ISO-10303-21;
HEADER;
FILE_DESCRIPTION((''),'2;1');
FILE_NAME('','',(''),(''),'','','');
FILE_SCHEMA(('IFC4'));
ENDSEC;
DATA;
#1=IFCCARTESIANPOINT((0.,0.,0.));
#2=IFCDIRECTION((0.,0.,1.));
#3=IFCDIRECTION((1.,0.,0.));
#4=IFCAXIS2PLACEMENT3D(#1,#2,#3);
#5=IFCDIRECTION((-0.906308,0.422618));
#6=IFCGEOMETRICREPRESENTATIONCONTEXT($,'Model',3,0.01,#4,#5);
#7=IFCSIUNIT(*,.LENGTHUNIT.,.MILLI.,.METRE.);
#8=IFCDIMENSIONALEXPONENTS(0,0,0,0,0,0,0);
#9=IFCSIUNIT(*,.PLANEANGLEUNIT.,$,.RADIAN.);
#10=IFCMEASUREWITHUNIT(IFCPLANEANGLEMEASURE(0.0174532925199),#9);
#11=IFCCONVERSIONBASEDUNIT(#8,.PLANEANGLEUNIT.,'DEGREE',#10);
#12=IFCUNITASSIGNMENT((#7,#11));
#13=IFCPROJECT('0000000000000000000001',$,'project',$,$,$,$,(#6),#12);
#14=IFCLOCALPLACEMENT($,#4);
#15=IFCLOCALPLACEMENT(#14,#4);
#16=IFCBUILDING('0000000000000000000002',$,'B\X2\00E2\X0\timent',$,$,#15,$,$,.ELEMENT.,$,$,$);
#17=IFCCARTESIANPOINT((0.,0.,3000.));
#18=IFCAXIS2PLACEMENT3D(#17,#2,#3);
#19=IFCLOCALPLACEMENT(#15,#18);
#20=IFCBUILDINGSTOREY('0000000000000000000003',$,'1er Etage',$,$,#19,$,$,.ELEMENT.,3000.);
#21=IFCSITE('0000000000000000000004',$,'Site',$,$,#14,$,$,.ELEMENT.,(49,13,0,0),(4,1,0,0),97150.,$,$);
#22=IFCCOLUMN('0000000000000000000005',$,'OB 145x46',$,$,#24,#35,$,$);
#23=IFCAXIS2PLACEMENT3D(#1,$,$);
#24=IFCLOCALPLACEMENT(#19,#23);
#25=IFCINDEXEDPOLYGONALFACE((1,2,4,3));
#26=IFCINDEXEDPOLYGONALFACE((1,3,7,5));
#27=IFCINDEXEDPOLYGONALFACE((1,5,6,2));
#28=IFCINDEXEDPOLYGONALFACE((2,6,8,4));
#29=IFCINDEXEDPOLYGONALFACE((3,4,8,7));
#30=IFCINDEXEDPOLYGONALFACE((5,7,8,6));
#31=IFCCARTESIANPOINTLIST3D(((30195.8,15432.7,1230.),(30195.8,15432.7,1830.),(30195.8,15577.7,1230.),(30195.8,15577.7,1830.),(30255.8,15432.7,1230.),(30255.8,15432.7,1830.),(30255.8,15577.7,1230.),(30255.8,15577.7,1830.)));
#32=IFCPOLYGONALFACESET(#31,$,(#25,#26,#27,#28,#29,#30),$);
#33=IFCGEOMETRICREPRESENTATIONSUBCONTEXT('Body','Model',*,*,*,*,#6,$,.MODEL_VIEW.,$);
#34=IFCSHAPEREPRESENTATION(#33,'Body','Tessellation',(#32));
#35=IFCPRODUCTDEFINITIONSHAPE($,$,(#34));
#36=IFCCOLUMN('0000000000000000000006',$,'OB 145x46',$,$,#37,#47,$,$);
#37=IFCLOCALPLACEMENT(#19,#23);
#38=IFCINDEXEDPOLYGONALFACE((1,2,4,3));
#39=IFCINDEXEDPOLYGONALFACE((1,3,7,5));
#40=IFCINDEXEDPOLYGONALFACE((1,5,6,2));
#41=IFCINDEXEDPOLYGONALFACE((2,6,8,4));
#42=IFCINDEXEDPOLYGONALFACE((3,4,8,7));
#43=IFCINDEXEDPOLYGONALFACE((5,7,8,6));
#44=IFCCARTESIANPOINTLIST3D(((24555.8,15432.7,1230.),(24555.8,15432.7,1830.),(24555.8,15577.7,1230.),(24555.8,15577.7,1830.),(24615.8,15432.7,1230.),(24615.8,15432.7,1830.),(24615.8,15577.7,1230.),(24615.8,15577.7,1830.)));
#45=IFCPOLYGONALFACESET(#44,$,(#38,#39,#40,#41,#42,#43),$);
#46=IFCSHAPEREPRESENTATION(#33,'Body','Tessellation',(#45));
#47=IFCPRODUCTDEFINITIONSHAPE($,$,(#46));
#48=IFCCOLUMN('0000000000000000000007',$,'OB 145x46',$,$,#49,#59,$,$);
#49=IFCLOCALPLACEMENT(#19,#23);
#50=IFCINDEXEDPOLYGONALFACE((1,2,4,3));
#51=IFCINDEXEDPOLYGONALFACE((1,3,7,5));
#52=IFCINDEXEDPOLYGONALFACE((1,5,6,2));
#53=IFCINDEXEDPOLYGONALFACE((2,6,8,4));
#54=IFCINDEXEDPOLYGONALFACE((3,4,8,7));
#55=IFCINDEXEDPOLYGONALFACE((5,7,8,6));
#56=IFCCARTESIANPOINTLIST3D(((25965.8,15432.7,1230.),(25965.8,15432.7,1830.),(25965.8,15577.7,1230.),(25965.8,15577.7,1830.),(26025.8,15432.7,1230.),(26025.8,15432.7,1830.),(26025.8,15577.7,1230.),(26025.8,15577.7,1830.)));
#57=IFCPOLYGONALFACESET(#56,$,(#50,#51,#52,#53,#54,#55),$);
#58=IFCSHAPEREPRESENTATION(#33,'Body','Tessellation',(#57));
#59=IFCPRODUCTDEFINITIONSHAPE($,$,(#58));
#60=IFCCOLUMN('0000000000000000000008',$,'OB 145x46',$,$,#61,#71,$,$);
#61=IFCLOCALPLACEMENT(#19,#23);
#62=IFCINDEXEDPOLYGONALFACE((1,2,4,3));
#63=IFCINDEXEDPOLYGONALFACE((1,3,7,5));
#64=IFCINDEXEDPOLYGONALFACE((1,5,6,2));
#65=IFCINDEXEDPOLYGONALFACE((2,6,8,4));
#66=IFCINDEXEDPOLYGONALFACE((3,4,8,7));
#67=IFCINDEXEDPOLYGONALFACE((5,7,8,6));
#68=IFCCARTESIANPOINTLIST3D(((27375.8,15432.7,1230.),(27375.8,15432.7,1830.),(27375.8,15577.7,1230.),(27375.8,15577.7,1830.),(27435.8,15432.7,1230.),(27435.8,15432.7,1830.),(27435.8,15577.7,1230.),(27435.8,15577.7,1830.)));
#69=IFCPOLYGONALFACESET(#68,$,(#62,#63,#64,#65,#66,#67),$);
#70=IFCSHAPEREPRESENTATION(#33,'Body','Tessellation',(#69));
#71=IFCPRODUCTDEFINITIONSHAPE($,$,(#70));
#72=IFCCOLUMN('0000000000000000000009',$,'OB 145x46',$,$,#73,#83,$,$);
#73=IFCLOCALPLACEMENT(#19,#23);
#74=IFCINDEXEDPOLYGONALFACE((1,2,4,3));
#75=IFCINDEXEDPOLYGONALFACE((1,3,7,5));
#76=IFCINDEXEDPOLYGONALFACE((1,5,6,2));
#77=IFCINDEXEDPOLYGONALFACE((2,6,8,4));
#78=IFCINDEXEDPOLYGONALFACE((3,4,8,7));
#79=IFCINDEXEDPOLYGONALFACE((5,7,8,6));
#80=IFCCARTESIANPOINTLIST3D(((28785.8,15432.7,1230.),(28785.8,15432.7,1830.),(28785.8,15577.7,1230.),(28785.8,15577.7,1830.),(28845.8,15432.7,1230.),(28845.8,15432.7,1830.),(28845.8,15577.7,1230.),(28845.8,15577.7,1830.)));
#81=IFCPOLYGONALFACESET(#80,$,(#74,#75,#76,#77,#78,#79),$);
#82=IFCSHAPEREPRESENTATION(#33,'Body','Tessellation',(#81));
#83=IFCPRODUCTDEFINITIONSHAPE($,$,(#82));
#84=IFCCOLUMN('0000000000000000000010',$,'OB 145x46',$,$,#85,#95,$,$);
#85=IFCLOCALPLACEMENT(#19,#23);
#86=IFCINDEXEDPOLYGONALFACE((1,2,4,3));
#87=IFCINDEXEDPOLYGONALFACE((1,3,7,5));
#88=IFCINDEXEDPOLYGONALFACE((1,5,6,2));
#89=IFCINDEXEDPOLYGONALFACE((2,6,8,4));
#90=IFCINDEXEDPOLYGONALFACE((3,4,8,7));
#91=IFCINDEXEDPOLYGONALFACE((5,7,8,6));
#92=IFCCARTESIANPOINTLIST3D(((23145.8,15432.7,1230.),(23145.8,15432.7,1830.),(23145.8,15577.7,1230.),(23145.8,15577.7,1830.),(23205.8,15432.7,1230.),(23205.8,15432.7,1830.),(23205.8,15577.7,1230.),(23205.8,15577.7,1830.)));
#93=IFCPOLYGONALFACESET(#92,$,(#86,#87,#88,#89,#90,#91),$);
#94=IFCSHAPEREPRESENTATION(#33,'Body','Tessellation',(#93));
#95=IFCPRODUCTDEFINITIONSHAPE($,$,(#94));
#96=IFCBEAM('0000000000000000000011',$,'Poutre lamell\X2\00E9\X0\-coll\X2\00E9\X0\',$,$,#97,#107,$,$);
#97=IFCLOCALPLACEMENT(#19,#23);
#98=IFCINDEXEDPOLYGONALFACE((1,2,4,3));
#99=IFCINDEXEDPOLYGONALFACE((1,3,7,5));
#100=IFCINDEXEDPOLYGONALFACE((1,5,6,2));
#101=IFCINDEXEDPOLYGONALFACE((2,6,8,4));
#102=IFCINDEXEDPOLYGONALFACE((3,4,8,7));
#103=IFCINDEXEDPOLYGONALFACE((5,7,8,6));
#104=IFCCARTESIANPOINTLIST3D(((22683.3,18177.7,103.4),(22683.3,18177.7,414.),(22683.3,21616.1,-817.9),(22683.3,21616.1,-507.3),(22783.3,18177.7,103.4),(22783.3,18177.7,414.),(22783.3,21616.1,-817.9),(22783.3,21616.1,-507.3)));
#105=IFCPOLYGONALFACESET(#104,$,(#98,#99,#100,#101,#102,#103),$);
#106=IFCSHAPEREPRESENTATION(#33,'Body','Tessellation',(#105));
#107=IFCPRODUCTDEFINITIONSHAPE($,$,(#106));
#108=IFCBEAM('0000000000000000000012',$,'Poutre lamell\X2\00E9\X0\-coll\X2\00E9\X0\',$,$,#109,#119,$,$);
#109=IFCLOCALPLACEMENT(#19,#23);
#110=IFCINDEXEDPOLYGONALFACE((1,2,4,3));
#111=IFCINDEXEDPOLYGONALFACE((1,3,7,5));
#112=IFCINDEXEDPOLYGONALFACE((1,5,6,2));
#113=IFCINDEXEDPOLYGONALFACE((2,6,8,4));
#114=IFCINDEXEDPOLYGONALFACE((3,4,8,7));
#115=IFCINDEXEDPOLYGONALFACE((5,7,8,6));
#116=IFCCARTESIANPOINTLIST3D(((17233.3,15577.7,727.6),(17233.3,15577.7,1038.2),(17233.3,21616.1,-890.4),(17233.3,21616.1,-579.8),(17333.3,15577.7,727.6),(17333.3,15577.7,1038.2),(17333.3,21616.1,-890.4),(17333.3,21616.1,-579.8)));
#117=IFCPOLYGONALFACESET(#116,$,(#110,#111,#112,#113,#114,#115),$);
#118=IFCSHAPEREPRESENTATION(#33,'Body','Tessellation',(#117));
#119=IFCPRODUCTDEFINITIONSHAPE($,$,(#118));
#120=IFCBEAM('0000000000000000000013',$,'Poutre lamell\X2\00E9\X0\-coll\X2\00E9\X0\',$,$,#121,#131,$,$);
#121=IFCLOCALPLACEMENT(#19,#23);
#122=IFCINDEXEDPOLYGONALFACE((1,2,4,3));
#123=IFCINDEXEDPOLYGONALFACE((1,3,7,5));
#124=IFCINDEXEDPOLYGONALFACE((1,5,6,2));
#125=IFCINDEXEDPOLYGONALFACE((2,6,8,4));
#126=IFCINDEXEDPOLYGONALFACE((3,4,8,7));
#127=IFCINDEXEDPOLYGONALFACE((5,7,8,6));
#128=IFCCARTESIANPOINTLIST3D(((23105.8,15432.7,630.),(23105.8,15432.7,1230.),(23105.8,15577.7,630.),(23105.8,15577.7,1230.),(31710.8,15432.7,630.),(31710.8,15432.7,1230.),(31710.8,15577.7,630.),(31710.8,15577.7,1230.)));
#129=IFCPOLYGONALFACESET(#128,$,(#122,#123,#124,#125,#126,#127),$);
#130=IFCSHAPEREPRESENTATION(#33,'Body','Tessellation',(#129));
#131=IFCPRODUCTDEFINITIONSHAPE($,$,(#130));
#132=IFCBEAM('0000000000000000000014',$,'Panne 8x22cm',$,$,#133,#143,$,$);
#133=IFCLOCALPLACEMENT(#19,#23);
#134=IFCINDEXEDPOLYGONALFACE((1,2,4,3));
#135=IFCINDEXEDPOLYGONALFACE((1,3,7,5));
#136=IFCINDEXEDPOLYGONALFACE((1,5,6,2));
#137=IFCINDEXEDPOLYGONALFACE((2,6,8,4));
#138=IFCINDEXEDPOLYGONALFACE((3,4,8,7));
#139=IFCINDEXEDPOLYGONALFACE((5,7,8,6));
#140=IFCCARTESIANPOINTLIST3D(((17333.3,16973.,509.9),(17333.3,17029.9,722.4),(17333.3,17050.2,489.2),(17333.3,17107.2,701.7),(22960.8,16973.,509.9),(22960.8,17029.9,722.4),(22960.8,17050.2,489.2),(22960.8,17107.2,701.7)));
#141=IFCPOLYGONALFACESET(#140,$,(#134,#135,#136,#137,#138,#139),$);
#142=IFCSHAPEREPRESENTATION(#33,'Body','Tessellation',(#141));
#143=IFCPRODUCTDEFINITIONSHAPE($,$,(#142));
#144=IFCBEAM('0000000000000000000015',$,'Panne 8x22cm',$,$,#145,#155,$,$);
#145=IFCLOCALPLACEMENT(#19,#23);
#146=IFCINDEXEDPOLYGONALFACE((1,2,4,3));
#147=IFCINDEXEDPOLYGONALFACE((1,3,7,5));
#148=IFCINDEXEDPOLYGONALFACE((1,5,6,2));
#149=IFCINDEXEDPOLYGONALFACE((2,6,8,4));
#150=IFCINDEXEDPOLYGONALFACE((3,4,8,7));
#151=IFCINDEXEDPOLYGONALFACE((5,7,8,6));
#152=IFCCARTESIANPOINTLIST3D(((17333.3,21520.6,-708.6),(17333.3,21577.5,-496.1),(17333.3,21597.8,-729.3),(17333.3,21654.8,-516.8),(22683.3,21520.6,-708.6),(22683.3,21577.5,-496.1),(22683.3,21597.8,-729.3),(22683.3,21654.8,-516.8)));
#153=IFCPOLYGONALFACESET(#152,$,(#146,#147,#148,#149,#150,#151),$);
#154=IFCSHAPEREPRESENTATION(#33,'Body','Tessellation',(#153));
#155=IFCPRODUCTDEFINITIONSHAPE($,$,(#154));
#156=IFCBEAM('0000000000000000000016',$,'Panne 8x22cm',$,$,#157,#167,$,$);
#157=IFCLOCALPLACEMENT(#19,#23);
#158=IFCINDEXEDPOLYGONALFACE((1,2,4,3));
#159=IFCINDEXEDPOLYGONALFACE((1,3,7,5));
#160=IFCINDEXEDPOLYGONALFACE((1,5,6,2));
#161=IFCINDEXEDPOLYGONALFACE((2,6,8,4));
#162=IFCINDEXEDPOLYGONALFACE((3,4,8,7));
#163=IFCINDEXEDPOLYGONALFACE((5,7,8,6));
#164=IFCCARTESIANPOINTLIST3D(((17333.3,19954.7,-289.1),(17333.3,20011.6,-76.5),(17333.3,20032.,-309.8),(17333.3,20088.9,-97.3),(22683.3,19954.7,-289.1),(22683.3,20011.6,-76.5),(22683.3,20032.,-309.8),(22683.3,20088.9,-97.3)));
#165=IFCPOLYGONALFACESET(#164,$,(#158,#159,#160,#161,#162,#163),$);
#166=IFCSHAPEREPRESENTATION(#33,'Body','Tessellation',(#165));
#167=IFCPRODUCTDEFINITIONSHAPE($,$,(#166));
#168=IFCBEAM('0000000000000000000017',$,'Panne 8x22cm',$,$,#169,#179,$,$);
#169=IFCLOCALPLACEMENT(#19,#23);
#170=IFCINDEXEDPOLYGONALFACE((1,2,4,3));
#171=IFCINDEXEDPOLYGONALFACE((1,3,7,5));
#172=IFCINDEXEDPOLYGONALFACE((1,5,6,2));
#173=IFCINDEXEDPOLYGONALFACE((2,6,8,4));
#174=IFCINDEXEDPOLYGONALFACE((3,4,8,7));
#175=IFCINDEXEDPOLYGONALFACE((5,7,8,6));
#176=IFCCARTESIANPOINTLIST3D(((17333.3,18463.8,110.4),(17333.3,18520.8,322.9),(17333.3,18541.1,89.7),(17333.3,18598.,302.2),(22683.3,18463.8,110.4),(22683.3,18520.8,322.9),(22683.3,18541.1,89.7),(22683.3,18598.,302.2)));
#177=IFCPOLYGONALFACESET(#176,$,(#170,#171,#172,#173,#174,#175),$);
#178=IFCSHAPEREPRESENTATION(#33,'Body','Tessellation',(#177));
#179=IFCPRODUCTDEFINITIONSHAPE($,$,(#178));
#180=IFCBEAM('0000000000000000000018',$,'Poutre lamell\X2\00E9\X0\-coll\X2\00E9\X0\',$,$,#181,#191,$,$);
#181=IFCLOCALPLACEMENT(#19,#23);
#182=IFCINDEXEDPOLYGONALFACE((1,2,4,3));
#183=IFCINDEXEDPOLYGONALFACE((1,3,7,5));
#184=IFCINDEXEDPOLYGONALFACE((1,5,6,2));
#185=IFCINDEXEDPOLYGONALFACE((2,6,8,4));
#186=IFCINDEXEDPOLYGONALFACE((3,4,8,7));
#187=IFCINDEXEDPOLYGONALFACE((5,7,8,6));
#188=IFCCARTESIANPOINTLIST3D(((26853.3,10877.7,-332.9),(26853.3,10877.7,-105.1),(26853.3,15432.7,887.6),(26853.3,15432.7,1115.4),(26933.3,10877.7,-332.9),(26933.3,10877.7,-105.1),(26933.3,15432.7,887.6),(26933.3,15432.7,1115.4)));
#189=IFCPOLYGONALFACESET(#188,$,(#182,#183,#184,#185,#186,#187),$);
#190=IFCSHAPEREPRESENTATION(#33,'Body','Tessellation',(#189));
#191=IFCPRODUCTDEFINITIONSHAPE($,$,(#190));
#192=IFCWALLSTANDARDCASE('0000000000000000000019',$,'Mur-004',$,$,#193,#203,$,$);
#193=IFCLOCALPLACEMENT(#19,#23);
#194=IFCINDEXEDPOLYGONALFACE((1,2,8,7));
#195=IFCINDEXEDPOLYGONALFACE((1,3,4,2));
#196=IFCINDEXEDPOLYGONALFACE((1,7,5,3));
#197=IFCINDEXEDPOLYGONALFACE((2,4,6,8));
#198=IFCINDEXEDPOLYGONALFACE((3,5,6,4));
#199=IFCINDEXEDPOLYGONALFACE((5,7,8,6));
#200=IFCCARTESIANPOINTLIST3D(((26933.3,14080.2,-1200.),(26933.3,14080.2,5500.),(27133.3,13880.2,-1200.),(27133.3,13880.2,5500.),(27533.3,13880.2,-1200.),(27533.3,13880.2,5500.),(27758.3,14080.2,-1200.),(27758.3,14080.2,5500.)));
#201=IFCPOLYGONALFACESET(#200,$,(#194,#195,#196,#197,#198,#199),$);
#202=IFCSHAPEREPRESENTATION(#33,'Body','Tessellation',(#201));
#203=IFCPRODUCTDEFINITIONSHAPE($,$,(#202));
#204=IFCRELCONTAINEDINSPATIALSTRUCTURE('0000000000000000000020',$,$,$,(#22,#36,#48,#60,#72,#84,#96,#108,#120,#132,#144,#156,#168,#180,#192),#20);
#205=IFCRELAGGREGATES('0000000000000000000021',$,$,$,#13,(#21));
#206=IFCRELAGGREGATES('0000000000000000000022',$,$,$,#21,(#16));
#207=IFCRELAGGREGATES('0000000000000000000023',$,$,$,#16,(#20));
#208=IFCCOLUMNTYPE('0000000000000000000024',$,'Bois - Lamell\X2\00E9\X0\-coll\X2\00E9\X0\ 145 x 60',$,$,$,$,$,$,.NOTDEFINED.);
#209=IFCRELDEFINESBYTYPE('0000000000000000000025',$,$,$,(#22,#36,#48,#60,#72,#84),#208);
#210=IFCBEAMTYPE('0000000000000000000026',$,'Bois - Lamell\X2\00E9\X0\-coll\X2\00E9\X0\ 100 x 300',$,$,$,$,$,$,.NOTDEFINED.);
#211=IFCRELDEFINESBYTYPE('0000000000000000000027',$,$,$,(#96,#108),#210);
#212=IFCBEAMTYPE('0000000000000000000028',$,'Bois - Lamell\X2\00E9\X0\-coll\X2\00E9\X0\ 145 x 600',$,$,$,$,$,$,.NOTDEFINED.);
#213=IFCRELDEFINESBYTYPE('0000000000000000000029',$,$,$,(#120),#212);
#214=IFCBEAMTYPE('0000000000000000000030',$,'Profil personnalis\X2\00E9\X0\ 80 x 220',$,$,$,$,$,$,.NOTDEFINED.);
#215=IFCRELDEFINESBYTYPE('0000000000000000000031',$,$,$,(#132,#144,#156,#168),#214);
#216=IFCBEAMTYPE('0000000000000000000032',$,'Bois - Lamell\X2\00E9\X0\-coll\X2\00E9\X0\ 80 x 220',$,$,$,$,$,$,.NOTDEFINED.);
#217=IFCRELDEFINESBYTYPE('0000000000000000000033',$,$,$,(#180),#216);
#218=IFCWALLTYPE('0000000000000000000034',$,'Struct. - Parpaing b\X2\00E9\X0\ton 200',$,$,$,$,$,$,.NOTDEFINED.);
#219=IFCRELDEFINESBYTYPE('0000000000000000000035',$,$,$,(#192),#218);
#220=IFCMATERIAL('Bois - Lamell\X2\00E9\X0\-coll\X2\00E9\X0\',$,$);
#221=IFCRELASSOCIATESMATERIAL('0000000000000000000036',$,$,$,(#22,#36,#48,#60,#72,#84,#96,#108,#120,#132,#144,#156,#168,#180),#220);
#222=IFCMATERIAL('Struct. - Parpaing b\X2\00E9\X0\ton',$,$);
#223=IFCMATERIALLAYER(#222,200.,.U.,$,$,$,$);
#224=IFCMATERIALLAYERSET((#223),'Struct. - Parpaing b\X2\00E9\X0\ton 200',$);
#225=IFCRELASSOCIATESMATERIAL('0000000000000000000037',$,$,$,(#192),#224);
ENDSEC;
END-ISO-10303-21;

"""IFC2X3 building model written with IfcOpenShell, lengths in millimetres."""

from ifc_helpers import new_model, entity, si_unit, converted_unit, direction, frame, frame_2d, origin_with_axes, origin_2d_with_axis, place, context, subcontext, project, spatial, polyline, rectangle, outline, extrude, clip, halfspace, material, layer, layer_set, layer_usage, type_object, element, save


model = new_model("IFC2X3")

# Units and contexts
model_context = context("Model", 3, precision=0.01, world=origin_with_axes(), true_north=direction((-0.906308, 0.422618)))
body_context = subcontext(model_context, "Body", "Model", "MODEL_VIEW")
ifc_project = project(units=[si_unit("LENGTHUNIT", "METRE", prefix="MILLI"), converted_unit("PLANEANGLEUNIT", "DEGREE", entity("IfcPlaneAngleMeasure", 0.0174532925199), si_unit("PLANEANGLEUNIT", "RADIAN"), dimensions=[0, 0, 0, 0, 0, 0, 0])], contexts=[model_context])

# Site, building, storey
site_placement = place(None, origin_with_axes())
site = spatial("IfcSite", under=ifc_project, at=site_placement, Name="Site", CompositionType="ELEMENT", RefLatitude=(49, 13, 0, 0), RefLongitude=(4, 1, 0, 0), RefElevation=97150.0)
building_placement = place(site_placement, origin_with_axes())
building = spatial("IfcBuilding", under=site, at=building_placement, Name="Bâtiment", CompositionType="ELEMENT")
storey_placement = place(building_placement, frame((0.0, 0.0, 3000.0), z_axis=(0.0, 0.0, 1.0), x_axis=(1.0, 0.0, 0.0)))
storey = spatial("IfcBuildingStorey", under=building, at=storey_placement, Name="1er Etage", CompositionType="ELEMENT", Elevation=3000.0)

# Columns
ifc_material_1 = material(Name="Bois - Lamellé-collé")
column_type = type_object("IfcColumnType", Name="Bois - Lamellé-collé 145 x 60", PredefinedType="NOTDEFINED")
for number, where, z_axis, x_axis, name in (
    (1, (30225.8, 15505.2, 1230.0), (0.0, 0.0, 1.0), (0.0, -1.0, 0.0), "OB 145x46"),
    (2, (24585.8, 15505.2, 1230.0), (0.0, 0.0, 1.0), (0.0, -1.0, 0.0), "OB 145x46"),
    (3, (25995.8, 15505.2, 1230.0), (0.0, 0.0, 1.0), (0.0, -1.0, 0.0), "OB 145x46"),
    (4, (27405.8, 15505.2, 1230.0), (0.0, 0.0, 1.0), (0.0, -1.0, 0.0), "OB 145x46"),
    (5, (28815.8, 15505.2, 1230.0), (0.0, 0.0, 1.0), (0.0, -1.0, 0.0), "OB 145x46"),
    (6, (23175.8, 15505.2, 1230.0), (0.0, 0.0, 1.0), (0.0, -1.0, 0.0), "OB 145x46"),
):
    element("IfcColumn", number, at=place(storey_placement, frame(where, z_axis=z_axis, x_axis=x_axis)), inside=storey, type_object=column_type, material=ifc_material_1, Name=name, context=body_context, shape_type="SweptSolid", body=[
        extrude(rectangle(XDim=145.0, YDim=60.0, at=origin_2d_with_axis()), origin_with_axes(), (0.0, 0.0, 1.0), 600.0),
    ])

# Beams
beam_type_1 = type_object("IfcBeamType", Name="Bois - Lamellé-collé 100 x 300", PredefinedType="NOTDEFINED")
beam_1_placement = place(storey_placement, frame((22733.3, 21616.1, -507.3), z_axis=(0.0, 0.0, 1.0), x_axis=(-1.0, 0.0, 0.0)))
element("IfcBeam", 7, at=beam_1_placement, inside=storey, type_object=beam_type_1, material=ifc_material_1, Name="Poutre lamellé-collé", context=body_context, shape_type="Clipping", body=[
    clip(clip(extrude(rectangle(XDim=300.0, YDim=100.0, at=frame_2d((-150.0, 0.0), x_axis=(1.0, 0.0))), frame((0.0, -109.8, -29.4), z_axis=(0.0, 0.965926, 0.258819), x_axis=(0.0, -0.258819, 0.965926)), (0.0, 0.0, 1.0), 3787.1), halfspace(frame((0.0, 0.0, 0.0), z_axis=(0.0, 1.0, 0.0), x_axis=(0.0, 0.0, 1.0)), True)), halfspace(frame((0.0, 3438.5, 0.0), z_axis=(0.0, -1.0, 0.0), x_axis=(0.0, 0.0, -1.0)), True)),
])
beam_2_placement = place(storey_placement, frame((17283.3, 21616.1, -579.8), z_axis=(0.0, 0.0, 1.0), x_axis=(-1.0, 0.0, 0.0)))
element("IfcBeam", 8, at=beam_2_placement, inside=storey, type_object=beam_type_1, material=ifc_material_1, Name="Poutre lamellé-collé", context=body_context, shape_type="Clipping", body=[
    clip(clip(extrude(rectangle(XDim=300.0, YDim=100.0, at=frame_2d((-150.0, 0.0), x_axis=(1.0, 0.0))), frame((0.0, -109.8, -29.4), z_axis=(0.0, 0.965926, 0.258819), x_axis=(0.0, -0.258819, 0.965926)), (0.0, 0.0, 1.0), 6478.8), halfspace(frame((0.0, 0.0, 0.0), z_axis=(0.0, 1.0, 0.0), x_axis=(0.0, 0.0, 1.0)), True)), halfspace(frame((0.0, 6038.5, 0.0), z_axis=(0.0, -1.0, 0.0), x_axis=(0.0, 0.0, -1.0)), True)),
])
beam_type_2 = type_object("IfcBeamType", Name="Bois - Lamellé-collé 145 x 600", PredefinedType="NOTDEFINED")
beam_3_placement = place(storey_placement, frame((23105.8, 15505.2, 1230.0), z_axis=(0.0, 0.0, 1.0), x_axis=(0.0, -1.0, 0.0)))
element("IfcBeam", 9, at=beam_3_placement, inside=storey, type_object=beam_type_2, material=ifc_material_1, Name="Poutre lamellé-collé", context=body_context, shape_type="SweptSolid", body=[
    extrude(rectangle(XDim=600.0, YDim=145.0, at=frame_2d((-300.0, 0.0), x_axis=(1.0, 0.0))), frame((0.0, 0.0, 0.0), z_axis=(0.0, 1.0, 0.0), x_axis=(0.0, 0.0, 1.0)), (0.0, 0.0, 1.0), 8605.0),
])
beam_type_3 = type_object("IfcBeamType", Name="Profil personnalisé 80 x 220", PredefinedType="NOTDEFINED")
beam_4_placement = place(storey_placement, frame((17333.3, 17068.5, 712.1), z_axis=(0.0, 0.0, 1.0), x_axis=(0.0, -1.0, 0.0)))
element("IfcBeam", 10, at=beam_4_placement, inside=storey, type_object=beam_type_3, material=ifc_material_1, Name="Panne 8x22cm", context=body_context, shape_type="SweptSolid", body=[
    extrude(outline(polyline([(-40.0, -220.0), (40.0, -220.0), (40.0, 0.0), (-40.0, 0.0), (-40.0, -220.0)])), frame((0.0, 5627.5, 0.0), z_axis=(0.0, -1.0, 0.0), x_axis=(0.965926, 0.0, 0.258819)), (0.0, 0.0, 1.0), 5627.5),
])
for number, where, z_axis, x_axis, name in (
    (11, (17333.3, 21616.1, -506.5), (0.0, 0.0, 1.0), (0.0, -1.0, 0.0), "Panne 8x22cm"),
    (12, (17333.3, 20050.3, -86.9), (0.0, 0.0, 1.0), (0.0, -1.0, 0.0), "Panne 8x22cm"),
    (13, (17333.3, 18559.4, 312.6), (0.0, 0.0, 1.0), (0.0, -1.0, 0.0), "Panne 8x22cm"),
):
    element("IfcBeam", number, at=place(storey_placement, frame(where, z_axis=z_axis, x_axis=x_axis)), inside=storey, type_object=beam_type_3, material=ifc_material_1, Name=name, context=body_context, shape_type="SweptSolid", body=[
        extrude(outline(polyline([(-40.0, -220.0), (40.0, -220.0), (40.0, 0.0), (-40.0, 0.0), (-40.0, -220.0)])), frame((0.0, 5350.0, 0.0), z_axis=(0.0, -1.0, 0.0), x_axis=(0.965926, 0.0, 0.258819)), (0.0, 0.0, 1.0), 5350.0),
    ])
beam_type_4 = type_object("IfcBeamType", Name="Bois - Lamellé-collé 80 x 220", PredefinedType="NOTDEFINED")
beam_5_placement = place(storey_placement, frame((26893.3, 10877.7, -105.1), z_axis=(0.0, 0.0, 1.0), x_axis=(1.0, 0.0, 0.0)))
element("IfcBeam", 14, at=beam_5_placement, inside=storey, type_object=beam_type_4, material=ifc_material_1, Name="Poutre lamellé-collé", context=body_context, shape_type="Clipping", body=[
    clip(clip(extrude(rectangle(XDim=220.0, YDim=80.0, at=frame_2d((-110.0, 0.0), x_axis=(1.0, 0.0))), frame((0.0, -80.5, -21.6), z_axis=(0.0, 0.965926, 0.258819), x_axis=(0.0, -0.258819, 0.965926)), (0.0, 0.0, 1.0), 4882.4), halfspace(frame((0.0, 0.0, 0.0), z_axis=(0.0, 1.0, 0.0), x_axis=(0.0, 0.0, 1.0)), True)), halfspace(frame((0.0, 4555.0, 0.0), z_axis=(0.0, -1.0, 0.0), x_axis=(0.0, 0.0, -1.0)), True)),
])

# Wall
ifc_material_2 = material(Name="Struct. - Parpaing béton")
ifc_layer_1 = layer(ifc_material_2, 200.0, ventilated="UNKNOWN")
ifc_layer_set_1 = layer_set([ifc_layer_1], Name="Struct. - Parpaing béton 200")
ifc_layer_usage_1 = layer_usage(ifc_layer_set_1, "AXIS2", "NEGATIVE", 0.0)
wall_type_1 = type_object("IfcWallType", Name="Struct. - Parpaing béton 200", PredefinedType="NOTDEFINED")
wall_1_placement = place(storey_placement, frame((27033.3, 14080.2, -1200.0), z_axis=(0.0, 0.0, 1.0), x_axis=(1.0, 0.0, 0.0)))
element("IfcWallStandardCase", 15, at=wall_1_placement, inside=storey, type_object=wall_type_1, material=ifc_layer_usage_1, Name="Mur-004", context=body_context, shape_type="SweptSolid", body=[
    extrude(outline(polyline([(100.0, -200.0), (500.0, -200.0), (725.0, 0.0), (-100.0, 0.0), (100.0, -200.0)])), origin_with_axes(), (0.0, 0.0, 1.0), 6700.0),
])

save(model, "model.ifc")
